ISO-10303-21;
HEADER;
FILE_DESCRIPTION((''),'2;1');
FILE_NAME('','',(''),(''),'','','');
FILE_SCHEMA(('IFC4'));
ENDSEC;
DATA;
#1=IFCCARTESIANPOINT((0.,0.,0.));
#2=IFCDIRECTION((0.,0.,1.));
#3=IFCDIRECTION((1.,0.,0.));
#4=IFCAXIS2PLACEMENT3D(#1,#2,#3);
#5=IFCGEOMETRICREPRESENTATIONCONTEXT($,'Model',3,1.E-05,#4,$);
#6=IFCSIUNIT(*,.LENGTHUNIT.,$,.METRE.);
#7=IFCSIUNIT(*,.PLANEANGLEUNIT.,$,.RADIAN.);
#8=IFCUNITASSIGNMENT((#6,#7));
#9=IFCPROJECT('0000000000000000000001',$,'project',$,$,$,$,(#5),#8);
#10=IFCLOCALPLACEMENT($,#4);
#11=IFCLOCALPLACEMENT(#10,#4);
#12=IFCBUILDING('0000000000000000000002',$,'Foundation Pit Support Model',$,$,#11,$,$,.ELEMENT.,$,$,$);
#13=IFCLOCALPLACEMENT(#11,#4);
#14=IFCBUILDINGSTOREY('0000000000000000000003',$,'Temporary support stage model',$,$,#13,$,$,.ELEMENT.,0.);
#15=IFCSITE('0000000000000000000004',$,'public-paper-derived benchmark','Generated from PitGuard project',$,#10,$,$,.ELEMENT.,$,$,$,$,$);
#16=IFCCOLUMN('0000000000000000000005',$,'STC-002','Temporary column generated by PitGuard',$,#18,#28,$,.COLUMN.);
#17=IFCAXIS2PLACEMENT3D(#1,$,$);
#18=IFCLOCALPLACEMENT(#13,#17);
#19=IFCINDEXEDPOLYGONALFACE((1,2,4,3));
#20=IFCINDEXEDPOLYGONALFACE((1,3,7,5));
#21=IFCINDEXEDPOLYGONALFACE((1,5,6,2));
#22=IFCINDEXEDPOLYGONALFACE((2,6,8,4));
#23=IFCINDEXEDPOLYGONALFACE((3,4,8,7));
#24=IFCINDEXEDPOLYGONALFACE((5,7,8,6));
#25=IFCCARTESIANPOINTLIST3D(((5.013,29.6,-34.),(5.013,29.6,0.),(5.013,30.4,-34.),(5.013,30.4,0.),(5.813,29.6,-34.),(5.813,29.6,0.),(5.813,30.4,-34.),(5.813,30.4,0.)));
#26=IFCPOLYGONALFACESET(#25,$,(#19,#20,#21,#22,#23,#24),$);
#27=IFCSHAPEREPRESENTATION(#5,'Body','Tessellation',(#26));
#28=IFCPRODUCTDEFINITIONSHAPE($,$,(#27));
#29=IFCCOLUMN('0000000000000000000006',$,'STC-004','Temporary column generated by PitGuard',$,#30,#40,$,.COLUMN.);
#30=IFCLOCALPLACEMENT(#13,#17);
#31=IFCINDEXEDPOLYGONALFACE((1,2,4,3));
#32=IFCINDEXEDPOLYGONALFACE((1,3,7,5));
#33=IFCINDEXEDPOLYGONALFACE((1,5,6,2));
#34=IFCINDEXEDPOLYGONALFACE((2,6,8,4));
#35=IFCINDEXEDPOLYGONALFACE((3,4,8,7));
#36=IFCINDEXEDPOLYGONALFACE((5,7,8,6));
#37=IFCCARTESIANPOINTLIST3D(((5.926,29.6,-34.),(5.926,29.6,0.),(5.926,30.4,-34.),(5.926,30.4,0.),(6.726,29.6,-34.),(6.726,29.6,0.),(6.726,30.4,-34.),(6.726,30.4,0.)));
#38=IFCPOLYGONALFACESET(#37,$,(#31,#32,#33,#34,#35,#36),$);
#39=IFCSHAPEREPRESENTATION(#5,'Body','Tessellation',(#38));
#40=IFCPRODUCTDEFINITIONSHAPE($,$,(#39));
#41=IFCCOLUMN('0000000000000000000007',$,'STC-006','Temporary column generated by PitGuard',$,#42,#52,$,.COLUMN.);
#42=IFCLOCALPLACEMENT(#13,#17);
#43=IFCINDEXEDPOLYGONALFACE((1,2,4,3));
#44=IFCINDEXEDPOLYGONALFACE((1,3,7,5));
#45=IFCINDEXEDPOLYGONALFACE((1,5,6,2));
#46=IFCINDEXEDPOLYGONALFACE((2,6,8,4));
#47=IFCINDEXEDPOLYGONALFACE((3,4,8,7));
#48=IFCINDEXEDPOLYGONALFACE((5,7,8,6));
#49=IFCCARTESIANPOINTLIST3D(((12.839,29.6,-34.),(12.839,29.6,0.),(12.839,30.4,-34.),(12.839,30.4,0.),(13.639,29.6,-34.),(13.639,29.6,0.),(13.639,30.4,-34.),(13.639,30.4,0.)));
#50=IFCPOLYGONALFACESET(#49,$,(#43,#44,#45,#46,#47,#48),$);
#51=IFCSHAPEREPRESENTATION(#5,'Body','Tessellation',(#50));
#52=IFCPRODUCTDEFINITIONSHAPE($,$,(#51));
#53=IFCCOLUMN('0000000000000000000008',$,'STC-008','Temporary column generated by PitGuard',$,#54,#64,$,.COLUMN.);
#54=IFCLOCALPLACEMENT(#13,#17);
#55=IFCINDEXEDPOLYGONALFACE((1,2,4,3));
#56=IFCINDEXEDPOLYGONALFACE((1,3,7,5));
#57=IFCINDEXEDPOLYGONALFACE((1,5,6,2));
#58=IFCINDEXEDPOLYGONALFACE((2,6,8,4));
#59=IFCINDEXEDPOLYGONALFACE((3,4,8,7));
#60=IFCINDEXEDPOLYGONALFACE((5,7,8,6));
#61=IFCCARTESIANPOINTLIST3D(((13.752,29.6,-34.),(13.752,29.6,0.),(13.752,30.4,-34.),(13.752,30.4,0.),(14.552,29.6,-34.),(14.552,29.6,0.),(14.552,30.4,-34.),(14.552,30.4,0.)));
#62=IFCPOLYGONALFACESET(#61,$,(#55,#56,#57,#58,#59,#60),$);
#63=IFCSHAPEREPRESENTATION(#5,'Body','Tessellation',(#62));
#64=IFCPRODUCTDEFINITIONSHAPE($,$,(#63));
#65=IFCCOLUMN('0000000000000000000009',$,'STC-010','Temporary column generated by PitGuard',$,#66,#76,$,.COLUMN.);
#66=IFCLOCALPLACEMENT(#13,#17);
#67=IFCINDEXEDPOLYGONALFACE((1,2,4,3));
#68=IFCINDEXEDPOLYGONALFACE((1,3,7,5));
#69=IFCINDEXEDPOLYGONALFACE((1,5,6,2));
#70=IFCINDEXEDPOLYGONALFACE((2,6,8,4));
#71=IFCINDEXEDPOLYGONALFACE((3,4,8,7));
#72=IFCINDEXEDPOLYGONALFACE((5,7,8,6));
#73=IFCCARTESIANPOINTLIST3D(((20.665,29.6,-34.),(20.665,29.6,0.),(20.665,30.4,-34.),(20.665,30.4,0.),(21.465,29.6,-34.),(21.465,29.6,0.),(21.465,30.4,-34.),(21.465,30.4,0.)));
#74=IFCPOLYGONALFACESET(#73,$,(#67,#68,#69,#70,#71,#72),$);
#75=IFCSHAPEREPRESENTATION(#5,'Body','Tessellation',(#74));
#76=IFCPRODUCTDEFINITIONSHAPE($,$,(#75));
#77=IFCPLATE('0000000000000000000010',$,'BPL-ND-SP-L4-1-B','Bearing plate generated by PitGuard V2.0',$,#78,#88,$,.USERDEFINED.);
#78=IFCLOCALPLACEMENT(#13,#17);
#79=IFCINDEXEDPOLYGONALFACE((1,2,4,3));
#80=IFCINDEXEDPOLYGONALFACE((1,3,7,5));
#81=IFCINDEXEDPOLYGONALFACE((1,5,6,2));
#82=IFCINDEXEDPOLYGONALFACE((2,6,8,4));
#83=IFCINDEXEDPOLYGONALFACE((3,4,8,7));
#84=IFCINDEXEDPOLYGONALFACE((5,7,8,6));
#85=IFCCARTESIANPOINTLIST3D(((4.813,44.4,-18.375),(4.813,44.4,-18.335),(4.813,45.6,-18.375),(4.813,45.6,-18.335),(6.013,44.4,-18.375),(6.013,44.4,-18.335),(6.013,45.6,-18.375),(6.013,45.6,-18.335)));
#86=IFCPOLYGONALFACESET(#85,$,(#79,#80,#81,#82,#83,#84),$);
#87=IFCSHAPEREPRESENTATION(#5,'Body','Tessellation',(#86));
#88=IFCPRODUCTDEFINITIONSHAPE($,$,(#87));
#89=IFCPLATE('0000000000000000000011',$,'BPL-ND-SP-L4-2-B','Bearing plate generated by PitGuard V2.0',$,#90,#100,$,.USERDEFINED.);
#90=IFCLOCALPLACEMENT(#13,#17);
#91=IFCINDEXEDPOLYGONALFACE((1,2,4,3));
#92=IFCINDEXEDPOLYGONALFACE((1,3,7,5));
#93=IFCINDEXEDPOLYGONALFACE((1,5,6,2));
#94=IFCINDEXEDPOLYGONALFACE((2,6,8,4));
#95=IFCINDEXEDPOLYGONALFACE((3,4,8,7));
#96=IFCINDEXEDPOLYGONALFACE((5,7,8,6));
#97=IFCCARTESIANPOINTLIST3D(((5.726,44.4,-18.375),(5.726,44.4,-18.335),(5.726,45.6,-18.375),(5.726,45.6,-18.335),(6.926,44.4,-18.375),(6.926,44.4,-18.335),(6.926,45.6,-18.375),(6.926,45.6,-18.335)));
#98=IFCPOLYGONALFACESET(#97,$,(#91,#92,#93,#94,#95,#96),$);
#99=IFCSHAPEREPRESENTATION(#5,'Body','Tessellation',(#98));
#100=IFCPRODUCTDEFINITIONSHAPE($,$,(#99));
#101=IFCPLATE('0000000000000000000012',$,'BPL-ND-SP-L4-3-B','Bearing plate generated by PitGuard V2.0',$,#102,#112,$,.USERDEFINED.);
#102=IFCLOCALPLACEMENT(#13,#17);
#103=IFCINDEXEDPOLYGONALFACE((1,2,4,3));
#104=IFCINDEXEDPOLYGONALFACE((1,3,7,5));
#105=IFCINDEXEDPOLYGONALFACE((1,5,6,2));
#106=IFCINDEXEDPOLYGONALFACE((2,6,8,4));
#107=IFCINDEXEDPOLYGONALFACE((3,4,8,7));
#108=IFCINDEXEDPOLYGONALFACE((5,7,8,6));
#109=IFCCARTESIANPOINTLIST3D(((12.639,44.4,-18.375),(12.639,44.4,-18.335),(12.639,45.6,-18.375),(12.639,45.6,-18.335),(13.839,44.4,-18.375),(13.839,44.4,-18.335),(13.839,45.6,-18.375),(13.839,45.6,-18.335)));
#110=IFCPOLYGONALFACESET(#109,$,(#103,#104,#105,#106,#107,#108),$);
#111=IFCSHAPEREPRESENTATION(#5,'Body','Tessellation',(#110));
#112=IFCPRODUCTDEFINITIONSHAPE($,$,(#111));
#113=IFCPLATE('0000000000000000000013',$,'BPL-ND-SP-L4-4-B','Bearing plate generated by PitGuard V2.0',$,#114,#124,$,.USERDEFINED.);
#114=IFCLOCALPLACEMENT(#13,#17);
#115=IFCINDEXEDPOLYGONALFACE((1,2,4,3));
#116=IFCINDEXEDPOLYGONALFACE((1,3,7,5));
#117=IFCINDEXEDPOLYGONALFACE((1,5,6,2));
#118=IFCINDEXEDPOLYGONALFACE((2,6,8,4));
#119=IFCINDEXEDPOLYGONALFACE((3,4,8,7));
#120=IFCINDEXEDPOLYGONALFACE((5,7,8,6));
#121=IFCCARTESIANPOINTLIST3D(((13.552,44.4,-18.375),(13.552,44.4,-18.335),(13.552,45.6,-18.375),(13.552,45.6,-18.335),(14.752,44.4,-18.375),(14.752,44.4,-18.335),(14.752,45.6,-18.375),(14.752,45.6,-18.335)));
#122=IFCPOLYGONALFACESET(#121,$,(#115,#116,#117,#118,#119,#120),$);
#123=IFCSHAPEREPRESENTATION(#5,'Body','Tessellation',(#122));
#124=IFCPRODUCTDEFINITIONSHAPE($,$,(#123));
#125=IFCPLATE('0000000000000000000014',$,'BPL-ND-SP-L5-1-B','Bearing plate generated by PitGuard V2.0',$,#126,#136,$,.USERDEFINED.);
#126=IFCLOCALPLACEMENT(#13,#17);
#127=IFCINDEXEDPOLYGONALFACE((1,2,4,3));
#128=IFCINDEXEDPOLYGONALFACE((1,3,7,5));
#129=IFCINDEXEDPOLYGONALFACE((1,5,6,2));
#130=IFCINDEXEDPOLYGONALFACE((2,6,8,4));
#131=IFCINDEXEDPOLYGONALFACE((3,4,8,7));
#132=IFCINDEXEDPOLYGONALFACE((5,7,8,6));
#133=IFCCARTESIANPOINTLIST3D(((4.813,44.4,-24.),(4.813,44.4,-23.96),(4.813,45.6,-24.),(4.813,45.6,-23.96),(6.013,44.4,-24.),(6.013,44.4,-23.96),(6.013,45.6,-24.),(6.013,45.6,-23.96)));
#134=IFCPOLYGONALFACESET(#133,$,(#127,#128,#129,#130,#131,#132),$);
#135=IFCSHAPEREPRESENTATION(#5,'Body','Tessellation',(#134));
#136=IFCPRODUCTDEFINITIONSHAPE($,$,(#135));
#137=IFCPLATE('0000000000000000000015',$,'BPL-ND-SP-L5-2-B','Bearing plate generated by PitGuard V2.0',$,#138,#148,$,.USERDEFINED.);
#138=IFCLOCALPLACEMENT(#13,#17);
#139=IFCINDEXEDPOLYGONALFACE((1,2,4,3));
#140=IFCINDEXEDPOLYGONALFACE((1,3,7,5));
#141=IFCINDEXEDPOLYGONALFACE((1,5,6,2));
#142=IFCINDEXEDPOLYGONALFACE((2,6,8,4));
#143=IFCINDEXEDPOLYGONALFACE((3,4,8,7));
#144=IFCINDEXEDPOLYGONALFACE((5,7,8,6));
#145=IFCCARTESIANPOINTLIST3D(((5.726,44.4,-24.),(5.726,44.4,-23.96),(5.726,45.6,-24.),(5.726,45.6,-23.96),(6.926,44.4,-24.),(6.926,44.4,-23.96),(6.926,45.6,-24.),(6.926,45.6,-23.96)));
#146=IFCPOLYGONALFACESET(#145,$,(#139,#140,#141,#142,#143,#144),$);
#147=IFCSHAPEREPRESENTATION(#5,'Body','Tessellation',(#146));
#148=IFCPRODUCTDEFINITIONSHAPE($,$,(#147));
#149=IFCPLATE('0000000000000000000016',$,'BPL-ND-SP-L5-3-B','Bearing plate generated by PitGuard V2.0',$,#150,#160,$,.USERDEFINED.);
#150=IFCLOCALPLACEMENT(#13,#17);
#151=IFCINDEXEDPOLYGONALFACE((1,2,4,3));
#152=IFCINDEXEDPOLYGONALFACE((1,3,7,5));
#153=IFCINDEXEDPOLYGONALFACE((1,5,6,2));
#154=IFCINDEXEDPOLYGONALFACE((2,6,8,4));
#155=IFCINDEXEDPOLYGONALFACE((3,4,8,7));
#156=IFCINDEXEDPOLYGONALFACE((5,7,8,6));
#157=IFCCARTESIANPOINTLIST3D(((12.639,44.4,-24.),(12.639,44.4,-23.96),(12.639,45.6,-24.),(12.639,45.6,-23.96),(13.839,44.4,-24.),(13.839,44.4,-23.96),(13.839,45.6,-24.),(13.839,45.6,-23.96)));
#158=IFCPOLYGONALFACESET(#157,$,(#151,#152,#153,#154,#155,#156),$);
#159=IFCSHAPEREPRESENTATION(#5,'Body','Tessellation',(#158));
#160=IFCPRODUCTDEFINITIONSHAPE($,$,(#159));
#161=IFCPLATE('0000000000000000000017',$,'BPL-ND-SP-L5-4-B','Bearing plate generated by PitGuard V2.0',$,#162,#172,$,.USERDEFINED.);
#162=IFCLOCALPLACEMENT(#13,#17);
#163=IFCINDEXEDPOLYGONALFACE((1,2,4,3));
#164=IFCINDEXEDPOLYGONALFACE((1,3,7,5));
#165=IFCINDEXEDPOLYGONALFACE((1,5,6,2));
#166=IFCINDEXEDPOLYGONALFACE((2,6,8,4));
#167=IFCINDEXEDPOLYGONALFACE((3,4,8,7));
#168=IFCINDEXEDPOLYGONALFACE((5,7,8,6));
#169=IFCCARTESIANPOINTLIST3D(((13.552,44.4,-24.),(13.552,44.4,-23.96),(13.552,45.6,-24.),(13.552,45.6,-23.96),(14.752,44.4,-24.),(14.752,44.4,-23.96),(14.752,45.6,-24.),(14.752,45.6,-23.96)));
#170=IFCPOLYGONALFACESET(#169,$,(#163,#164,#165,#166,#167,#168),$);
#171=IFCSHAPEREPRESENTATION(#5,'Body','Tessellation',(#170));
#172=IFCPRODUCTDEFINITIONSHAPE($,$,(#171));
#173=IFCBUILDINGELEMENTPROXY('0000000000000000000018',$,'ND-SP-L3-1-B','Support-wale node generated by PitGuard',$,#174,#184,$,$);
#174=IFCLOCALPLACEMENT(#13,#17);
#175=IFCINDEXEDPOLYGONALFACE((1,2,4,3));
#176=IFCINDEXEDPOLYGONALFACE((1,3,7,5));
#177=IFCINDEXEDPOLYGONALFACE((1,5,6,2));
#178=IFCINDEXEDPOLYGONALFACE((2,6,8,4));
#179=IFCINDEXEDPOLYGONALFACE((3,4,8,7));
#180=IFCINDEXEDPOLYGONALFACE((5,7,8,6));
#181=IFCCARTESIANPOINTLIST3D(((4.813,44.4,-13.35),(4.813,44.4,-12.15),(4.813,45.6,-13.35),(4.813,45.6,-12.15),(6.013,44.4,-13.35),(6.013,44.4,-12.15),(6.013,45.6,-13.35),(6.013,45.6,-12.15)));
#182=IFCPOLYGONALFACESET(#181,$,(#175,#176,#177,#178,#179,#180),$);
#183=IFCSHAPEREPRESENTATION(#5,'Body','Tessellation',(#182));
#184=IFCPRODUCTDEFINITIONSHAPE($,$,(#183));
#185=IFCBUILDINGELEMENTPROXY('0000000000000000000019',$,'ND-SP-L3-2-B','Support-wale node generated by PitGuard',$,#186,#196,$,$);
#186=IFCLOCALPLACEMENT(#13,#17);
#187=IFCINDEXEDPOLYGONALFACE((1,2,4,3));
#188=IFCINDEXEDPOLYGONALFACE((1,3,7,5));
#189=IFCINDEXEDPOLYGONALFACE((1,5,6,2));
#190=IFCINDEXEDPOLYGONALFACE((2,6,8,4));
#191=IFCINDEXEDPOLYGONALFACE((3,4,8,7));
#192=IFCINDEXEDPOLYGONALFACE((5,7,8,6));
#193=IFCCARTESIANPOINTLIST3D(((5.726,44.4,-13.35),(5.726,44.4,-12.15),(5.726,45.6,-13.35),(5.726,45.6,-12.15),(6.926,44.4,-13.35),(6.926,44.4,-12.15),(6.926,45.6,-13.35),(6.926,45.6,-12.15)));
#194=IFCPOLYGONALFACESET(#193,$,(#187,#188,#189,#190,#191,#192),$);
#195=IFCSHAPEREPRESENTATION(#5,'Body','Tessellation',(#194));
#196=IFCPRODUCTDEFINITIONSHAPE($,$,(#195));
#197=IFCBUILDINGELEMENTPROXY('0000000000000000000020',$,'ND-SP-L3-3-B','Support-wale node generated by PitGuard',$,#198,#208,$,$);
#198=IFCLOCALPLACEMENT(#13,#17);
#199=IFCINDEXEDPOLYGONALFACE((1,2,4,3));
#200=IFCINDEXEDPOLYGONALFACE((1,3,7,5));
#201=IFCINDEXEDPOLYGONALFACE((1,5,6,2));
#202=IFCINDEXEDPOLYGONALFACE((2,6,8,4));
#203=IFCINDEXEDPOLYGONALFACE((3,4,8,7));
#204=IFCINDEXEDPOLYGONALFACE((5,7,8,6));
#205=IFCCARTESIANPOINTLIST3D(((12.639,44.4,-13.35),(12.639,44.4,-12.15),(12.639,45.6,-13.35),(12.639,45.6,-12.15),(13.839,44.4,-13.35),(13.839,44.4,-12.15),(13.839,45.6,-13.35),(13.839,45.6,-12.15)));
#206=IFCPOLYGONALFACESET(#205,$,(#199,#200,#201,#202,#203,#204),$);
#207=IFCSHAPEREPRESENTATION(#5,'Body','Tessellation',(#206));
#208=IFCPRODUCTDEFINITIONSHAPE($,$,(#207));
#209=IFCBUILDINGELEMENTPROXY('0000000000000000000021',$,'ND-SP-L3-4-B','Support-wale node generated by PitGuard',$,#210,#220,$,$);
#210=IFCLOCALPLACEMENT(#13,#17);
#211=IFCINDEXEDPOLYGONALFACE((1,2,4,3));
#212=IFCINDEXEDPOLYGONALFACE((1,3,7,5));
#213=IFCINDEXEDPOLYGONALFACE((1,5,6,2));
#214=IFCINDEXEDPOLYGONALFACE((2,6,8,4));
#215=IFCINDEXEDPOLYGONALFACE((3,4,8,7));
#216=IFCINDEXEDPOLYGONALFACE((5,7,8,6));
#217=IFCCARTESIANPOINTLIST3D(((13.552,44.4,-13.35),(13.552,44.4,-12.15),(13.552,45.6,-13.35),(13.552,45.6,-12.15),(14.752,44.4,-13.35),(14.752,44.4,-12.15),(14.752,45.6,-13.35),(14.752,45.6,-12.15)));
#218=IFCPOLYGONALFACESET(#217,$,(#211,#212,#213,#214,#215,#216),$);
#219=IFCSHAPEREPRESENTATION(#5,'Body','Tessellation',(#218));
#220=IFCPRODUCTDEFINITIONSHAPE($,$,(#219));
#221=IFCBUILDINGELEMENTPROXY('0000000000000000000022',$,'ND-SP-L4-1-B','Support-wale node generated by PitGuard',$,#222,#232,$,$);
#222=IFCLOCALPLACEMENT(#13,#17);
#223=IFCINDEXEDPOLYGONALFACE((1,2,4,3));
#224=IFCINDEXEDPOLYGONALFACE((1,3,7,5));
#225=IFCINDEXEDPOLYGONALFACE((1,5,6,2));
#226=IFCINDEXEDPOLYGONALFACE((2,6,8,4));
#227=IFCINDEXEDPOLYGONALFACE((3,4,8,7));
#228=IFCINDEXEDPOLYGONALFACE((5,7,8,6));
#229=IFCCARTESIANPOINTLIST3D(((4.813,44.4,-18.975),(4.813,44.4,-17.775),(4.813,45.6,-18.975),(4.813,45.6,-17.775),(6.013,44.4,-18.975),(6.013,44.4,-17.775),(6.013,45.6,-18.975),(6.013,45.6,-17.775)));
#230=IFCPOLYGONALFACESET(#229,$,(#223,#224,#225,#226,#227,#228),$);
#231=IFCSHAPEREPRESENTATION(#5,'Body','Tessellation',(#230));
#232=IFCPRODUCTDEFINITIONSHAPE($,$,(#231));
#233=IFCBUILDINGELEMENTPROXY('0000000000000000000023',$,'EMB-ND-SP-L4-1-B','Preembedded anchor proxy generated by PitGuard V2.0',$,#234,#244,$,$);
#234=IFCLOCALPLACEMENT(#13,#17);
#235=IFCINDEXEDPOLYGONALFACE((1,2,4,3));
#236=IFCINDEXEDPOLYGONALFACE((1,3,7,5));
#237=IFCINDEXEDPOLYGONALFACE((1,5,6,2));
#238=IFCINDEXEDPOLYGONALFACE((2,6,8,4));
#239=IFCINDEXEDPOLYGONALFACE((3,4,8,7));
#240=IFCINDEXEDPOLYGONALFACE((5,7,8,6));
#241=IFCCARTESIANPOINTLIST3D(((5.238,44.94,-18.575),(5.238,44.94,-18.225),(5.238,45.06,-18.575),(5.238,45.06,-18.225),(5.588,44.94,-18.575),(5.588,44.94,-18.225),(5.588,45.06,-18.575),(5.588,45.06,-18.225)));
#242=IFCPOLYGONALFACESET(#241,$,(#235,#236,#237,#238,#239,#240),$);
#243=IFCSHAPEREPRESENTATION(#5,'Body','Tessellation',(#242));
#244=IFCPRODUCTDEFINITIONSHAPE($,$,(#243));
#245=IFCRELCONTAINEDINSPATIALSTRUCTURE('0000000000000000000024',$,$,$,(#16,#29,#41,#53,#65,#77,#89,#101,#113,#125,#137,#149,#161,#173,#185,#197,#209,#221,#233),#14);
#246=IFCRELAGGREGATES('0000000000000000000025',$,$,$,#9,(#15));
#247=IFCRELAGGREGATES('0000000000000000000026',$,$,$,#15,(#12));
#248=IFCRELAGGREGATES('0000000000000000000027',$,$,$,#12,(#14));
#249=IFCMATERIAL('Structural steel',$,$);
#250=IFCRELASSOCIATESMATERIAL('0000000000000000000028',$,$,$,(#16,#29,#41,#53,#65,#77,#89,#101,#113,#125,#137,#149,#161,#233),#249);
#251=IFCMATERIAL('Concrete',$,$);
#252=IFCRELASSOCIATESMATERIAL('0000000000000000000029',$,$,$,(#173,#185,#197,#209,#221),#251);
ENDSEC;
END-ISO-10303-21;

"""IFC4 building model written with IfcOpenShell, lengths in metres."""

from ifc_helpers import new_model, si_unit, frame, origin_with_axes, origin_2d, place, context, project, spatial, rectangle, extrude, material, element, save


model = new_model("IFC4")

# Units and contexts
model_context = context("Model", 3, precision=1e-05, world=origin_with_axes())
ifc_project = project(units=[si_unit("LENGTHUNIT", "METRE"), si_unit("PLANEANGLEUNIT", "RADIAN")], contexts=[model_context])

# Site, building, storey
site_placement = place(None, origin_with_axes())
site = spatial("IfcSite", under=ifc_project, at=site_placement, Name="public-paper-derived benchmark", Description="Generated from PitGuard project", CompositionType="ELEMENT")
building_placement = place(site_placement, origin_with_axes())
building = spatial("IfcBuilding", under=site, at=building_placement, Name="Foundation Pit Support Model", CompositionType="ELEMENT")
storey_placement = place(building_placement, origin_with_axes())
storey = spatial("IfcBuildingStorey", under=building, at=storey_placement, Name="Temporary support stage model", CompositionType="ELEMENT", Elevation=0.0)

# Columns
ifc_material_1 = material(Name="Structural steel")
for number, where, z_axis, x_axis, name in (
    (1, (5.413, 30.0, -34.0), (0.0, 0.0, 1.0), (1.0, 0.0, 0.0), "STC-002"),
    (2, (6.326, 30.0, -34.0), (0.0, 0.0, 1.0), (1.0, 0.0, 0.0), "STC-004"),
    (3, (13.239, 30.0, -34.0), (0.0, 0.0, 1.0), (1.0, 0.0, 0.0), "STC-006"),
    (4, (14.152, 30.0, -34.0), (0.0, 0.0, 1.0), (1.0, 0.0, 0.0), "STC-008"),
    (5, (21.065, 30.0, -34.0), (0.0, 0.0, 1.0), (1.0, 0.0, 0.0), "STC-010"),
):
    element("IfcColumn", number, at=place(storey_placement, frame(where, z_axis=z_axis, x_axis=x_axis)), inside=storey, material=ifc_material_1, Name=name, Description="Temporary column generated by PitGuard", PredefinedType="COLUMN", context=model_context, shape_type="SweptSolid", body=[
        extrude(rectangle(XDim=0.8, YDim=0.8, at=origin_2d()), origin_with_axes(), (0.0, 0.0, 1.0), 34.0),
    ])

# Plates
for number, where, z_axis, x_axis, name in (
    (6, (5.413, 45.0, -18.375), (0.0, 0.0, 1.0), (1.0, 0.0, 0.0), "BPL-ND-SP-L4-1-B"),
    (7, (6.326, 45.0, -18.375), (0.0, 0.0, 1.0), (1.0, 0.0, 0.0), "BPL-ND-SP-L4-2-B"),
    (8, (13.239, 45.0, -18.375), (0.0, 0.0, 1.0), (1.0, 0.0, 0.0), "BPL-ND-SP-L4-3-B"),
    (9, (14.152, 45.0, -18.375), (0.0, 0.0, 1.0), (1.0, 0.0, 0.0), "BPL-ND-SP-L4-4-B"),
    (10, (5.413, 45.0, -24.0), (0.0, 0.0, 1.0), (1.0, 0.0, 0.0), "BPL-ND-SP-L5-1-B"),
    (11, (6.326, 45.0, -24.0), (0.0, 0.0, 1.0), (1.0, 0.0, 0.0), "BPL-ND-SP-L5-2-B"),
    (12, (13.239, 45.0, -24.0), (0.0, 0.0, 1.0), (1.0, 0.0, 0.0), "BPL-ND-SP-L5-3-B"),
    (13, (14.152, 45.0, -24.0), (0.0, 0.0, 1.0), (1.0, 0.0, 0.0), "BPL-ND-SP-L5-4-B"),
):
    element("IfcPlate", number, at=place(storey_placement, frame(where, z_axis=z_axis, x_axis=x_axis)), inside=storey, material=ifc_material_1, Name=name, Description="Bearing plate generated by PitGuard V2.0", PredefinedType="USERDEFINED", context=model_context, shape_type="SweptSolid", body=[
        extrude(rectangle(XDim=1.2, YDim=1.2, at=origin_2d()), origin_with_axes(), (0.0, 0.0, 1.0), 0.04),
    ])

# Building element proxies
ifc_material_2 = material(Name="Concrete")
for number, where, z_axis, x_axis, name in (
    (14, (5.413, 45.0, -13.35), (0.0, 0.0, 1.0), (1.0, 0.0, 0.0), "ND-SP-L3-1-B"),
    (15, (6.326, 45.0, -13.35), (0.0, 0.0, 1.0), (1.0, 0.0, 0.0), "ND-SP-L3-2-B"),
    (16, (13.239, 45.0, -13.35), (0.0, 0.0, 1.0), (1.0, 0.0, 0.0), "ND-SP-L3-3-B"),
    (17, (14.152, 45.0, -13.35), (0.0, 0.0, 1.0), (1.0, 0.0, 0.0), "ND-SP-L3-4-B"),
    (18, (5.413, 45.0, -18.975), (0.0, 0.0, 1.0), (1.0, 0.0, 0.0), "ND-SP-L4-1-B"),
):
    element("IfcBuildingElementProxy", number, at=place(storey_placement, frame(where, z_axis=z_axis, x_axis=x_axis)), inside=storey, material=ifc_material_2, Name=name, Description="Support-wale node generated by PitGuard", context=model_context, shape_type="SweptSolid", body=[
        extrude(rectangle(XDim=1.2, YDim=1.2, at=origin_2d()), origin_with_axes(), (0.0, 0.0, 1.0), 1.2),
    ])
proxy_1_placement = place(storey_placement, frame((5.413, 45.0, -18.575), z_axis=(0.0, 0.0, 1.0), x_axis=(1.0, 0.0, 0.0)))
element("IfcBuildingElementProxy", 19, at=proxy_1_placement, inside=storey, material=ifc_material_1, Name="EMB-ND-SP-L4-1-B", Description="Preembedded anchor proxy generated by PitGuard V2.0", context=model_context, shape_type="SweptSolid", body=[
    extrude(rectangle(XDim=0.35, YDim=0.12, at=origin_2d()), origin_with_axes(), (0.0, 0.0, 1.0), 0.35),
])

save(model, "model.ifc")
